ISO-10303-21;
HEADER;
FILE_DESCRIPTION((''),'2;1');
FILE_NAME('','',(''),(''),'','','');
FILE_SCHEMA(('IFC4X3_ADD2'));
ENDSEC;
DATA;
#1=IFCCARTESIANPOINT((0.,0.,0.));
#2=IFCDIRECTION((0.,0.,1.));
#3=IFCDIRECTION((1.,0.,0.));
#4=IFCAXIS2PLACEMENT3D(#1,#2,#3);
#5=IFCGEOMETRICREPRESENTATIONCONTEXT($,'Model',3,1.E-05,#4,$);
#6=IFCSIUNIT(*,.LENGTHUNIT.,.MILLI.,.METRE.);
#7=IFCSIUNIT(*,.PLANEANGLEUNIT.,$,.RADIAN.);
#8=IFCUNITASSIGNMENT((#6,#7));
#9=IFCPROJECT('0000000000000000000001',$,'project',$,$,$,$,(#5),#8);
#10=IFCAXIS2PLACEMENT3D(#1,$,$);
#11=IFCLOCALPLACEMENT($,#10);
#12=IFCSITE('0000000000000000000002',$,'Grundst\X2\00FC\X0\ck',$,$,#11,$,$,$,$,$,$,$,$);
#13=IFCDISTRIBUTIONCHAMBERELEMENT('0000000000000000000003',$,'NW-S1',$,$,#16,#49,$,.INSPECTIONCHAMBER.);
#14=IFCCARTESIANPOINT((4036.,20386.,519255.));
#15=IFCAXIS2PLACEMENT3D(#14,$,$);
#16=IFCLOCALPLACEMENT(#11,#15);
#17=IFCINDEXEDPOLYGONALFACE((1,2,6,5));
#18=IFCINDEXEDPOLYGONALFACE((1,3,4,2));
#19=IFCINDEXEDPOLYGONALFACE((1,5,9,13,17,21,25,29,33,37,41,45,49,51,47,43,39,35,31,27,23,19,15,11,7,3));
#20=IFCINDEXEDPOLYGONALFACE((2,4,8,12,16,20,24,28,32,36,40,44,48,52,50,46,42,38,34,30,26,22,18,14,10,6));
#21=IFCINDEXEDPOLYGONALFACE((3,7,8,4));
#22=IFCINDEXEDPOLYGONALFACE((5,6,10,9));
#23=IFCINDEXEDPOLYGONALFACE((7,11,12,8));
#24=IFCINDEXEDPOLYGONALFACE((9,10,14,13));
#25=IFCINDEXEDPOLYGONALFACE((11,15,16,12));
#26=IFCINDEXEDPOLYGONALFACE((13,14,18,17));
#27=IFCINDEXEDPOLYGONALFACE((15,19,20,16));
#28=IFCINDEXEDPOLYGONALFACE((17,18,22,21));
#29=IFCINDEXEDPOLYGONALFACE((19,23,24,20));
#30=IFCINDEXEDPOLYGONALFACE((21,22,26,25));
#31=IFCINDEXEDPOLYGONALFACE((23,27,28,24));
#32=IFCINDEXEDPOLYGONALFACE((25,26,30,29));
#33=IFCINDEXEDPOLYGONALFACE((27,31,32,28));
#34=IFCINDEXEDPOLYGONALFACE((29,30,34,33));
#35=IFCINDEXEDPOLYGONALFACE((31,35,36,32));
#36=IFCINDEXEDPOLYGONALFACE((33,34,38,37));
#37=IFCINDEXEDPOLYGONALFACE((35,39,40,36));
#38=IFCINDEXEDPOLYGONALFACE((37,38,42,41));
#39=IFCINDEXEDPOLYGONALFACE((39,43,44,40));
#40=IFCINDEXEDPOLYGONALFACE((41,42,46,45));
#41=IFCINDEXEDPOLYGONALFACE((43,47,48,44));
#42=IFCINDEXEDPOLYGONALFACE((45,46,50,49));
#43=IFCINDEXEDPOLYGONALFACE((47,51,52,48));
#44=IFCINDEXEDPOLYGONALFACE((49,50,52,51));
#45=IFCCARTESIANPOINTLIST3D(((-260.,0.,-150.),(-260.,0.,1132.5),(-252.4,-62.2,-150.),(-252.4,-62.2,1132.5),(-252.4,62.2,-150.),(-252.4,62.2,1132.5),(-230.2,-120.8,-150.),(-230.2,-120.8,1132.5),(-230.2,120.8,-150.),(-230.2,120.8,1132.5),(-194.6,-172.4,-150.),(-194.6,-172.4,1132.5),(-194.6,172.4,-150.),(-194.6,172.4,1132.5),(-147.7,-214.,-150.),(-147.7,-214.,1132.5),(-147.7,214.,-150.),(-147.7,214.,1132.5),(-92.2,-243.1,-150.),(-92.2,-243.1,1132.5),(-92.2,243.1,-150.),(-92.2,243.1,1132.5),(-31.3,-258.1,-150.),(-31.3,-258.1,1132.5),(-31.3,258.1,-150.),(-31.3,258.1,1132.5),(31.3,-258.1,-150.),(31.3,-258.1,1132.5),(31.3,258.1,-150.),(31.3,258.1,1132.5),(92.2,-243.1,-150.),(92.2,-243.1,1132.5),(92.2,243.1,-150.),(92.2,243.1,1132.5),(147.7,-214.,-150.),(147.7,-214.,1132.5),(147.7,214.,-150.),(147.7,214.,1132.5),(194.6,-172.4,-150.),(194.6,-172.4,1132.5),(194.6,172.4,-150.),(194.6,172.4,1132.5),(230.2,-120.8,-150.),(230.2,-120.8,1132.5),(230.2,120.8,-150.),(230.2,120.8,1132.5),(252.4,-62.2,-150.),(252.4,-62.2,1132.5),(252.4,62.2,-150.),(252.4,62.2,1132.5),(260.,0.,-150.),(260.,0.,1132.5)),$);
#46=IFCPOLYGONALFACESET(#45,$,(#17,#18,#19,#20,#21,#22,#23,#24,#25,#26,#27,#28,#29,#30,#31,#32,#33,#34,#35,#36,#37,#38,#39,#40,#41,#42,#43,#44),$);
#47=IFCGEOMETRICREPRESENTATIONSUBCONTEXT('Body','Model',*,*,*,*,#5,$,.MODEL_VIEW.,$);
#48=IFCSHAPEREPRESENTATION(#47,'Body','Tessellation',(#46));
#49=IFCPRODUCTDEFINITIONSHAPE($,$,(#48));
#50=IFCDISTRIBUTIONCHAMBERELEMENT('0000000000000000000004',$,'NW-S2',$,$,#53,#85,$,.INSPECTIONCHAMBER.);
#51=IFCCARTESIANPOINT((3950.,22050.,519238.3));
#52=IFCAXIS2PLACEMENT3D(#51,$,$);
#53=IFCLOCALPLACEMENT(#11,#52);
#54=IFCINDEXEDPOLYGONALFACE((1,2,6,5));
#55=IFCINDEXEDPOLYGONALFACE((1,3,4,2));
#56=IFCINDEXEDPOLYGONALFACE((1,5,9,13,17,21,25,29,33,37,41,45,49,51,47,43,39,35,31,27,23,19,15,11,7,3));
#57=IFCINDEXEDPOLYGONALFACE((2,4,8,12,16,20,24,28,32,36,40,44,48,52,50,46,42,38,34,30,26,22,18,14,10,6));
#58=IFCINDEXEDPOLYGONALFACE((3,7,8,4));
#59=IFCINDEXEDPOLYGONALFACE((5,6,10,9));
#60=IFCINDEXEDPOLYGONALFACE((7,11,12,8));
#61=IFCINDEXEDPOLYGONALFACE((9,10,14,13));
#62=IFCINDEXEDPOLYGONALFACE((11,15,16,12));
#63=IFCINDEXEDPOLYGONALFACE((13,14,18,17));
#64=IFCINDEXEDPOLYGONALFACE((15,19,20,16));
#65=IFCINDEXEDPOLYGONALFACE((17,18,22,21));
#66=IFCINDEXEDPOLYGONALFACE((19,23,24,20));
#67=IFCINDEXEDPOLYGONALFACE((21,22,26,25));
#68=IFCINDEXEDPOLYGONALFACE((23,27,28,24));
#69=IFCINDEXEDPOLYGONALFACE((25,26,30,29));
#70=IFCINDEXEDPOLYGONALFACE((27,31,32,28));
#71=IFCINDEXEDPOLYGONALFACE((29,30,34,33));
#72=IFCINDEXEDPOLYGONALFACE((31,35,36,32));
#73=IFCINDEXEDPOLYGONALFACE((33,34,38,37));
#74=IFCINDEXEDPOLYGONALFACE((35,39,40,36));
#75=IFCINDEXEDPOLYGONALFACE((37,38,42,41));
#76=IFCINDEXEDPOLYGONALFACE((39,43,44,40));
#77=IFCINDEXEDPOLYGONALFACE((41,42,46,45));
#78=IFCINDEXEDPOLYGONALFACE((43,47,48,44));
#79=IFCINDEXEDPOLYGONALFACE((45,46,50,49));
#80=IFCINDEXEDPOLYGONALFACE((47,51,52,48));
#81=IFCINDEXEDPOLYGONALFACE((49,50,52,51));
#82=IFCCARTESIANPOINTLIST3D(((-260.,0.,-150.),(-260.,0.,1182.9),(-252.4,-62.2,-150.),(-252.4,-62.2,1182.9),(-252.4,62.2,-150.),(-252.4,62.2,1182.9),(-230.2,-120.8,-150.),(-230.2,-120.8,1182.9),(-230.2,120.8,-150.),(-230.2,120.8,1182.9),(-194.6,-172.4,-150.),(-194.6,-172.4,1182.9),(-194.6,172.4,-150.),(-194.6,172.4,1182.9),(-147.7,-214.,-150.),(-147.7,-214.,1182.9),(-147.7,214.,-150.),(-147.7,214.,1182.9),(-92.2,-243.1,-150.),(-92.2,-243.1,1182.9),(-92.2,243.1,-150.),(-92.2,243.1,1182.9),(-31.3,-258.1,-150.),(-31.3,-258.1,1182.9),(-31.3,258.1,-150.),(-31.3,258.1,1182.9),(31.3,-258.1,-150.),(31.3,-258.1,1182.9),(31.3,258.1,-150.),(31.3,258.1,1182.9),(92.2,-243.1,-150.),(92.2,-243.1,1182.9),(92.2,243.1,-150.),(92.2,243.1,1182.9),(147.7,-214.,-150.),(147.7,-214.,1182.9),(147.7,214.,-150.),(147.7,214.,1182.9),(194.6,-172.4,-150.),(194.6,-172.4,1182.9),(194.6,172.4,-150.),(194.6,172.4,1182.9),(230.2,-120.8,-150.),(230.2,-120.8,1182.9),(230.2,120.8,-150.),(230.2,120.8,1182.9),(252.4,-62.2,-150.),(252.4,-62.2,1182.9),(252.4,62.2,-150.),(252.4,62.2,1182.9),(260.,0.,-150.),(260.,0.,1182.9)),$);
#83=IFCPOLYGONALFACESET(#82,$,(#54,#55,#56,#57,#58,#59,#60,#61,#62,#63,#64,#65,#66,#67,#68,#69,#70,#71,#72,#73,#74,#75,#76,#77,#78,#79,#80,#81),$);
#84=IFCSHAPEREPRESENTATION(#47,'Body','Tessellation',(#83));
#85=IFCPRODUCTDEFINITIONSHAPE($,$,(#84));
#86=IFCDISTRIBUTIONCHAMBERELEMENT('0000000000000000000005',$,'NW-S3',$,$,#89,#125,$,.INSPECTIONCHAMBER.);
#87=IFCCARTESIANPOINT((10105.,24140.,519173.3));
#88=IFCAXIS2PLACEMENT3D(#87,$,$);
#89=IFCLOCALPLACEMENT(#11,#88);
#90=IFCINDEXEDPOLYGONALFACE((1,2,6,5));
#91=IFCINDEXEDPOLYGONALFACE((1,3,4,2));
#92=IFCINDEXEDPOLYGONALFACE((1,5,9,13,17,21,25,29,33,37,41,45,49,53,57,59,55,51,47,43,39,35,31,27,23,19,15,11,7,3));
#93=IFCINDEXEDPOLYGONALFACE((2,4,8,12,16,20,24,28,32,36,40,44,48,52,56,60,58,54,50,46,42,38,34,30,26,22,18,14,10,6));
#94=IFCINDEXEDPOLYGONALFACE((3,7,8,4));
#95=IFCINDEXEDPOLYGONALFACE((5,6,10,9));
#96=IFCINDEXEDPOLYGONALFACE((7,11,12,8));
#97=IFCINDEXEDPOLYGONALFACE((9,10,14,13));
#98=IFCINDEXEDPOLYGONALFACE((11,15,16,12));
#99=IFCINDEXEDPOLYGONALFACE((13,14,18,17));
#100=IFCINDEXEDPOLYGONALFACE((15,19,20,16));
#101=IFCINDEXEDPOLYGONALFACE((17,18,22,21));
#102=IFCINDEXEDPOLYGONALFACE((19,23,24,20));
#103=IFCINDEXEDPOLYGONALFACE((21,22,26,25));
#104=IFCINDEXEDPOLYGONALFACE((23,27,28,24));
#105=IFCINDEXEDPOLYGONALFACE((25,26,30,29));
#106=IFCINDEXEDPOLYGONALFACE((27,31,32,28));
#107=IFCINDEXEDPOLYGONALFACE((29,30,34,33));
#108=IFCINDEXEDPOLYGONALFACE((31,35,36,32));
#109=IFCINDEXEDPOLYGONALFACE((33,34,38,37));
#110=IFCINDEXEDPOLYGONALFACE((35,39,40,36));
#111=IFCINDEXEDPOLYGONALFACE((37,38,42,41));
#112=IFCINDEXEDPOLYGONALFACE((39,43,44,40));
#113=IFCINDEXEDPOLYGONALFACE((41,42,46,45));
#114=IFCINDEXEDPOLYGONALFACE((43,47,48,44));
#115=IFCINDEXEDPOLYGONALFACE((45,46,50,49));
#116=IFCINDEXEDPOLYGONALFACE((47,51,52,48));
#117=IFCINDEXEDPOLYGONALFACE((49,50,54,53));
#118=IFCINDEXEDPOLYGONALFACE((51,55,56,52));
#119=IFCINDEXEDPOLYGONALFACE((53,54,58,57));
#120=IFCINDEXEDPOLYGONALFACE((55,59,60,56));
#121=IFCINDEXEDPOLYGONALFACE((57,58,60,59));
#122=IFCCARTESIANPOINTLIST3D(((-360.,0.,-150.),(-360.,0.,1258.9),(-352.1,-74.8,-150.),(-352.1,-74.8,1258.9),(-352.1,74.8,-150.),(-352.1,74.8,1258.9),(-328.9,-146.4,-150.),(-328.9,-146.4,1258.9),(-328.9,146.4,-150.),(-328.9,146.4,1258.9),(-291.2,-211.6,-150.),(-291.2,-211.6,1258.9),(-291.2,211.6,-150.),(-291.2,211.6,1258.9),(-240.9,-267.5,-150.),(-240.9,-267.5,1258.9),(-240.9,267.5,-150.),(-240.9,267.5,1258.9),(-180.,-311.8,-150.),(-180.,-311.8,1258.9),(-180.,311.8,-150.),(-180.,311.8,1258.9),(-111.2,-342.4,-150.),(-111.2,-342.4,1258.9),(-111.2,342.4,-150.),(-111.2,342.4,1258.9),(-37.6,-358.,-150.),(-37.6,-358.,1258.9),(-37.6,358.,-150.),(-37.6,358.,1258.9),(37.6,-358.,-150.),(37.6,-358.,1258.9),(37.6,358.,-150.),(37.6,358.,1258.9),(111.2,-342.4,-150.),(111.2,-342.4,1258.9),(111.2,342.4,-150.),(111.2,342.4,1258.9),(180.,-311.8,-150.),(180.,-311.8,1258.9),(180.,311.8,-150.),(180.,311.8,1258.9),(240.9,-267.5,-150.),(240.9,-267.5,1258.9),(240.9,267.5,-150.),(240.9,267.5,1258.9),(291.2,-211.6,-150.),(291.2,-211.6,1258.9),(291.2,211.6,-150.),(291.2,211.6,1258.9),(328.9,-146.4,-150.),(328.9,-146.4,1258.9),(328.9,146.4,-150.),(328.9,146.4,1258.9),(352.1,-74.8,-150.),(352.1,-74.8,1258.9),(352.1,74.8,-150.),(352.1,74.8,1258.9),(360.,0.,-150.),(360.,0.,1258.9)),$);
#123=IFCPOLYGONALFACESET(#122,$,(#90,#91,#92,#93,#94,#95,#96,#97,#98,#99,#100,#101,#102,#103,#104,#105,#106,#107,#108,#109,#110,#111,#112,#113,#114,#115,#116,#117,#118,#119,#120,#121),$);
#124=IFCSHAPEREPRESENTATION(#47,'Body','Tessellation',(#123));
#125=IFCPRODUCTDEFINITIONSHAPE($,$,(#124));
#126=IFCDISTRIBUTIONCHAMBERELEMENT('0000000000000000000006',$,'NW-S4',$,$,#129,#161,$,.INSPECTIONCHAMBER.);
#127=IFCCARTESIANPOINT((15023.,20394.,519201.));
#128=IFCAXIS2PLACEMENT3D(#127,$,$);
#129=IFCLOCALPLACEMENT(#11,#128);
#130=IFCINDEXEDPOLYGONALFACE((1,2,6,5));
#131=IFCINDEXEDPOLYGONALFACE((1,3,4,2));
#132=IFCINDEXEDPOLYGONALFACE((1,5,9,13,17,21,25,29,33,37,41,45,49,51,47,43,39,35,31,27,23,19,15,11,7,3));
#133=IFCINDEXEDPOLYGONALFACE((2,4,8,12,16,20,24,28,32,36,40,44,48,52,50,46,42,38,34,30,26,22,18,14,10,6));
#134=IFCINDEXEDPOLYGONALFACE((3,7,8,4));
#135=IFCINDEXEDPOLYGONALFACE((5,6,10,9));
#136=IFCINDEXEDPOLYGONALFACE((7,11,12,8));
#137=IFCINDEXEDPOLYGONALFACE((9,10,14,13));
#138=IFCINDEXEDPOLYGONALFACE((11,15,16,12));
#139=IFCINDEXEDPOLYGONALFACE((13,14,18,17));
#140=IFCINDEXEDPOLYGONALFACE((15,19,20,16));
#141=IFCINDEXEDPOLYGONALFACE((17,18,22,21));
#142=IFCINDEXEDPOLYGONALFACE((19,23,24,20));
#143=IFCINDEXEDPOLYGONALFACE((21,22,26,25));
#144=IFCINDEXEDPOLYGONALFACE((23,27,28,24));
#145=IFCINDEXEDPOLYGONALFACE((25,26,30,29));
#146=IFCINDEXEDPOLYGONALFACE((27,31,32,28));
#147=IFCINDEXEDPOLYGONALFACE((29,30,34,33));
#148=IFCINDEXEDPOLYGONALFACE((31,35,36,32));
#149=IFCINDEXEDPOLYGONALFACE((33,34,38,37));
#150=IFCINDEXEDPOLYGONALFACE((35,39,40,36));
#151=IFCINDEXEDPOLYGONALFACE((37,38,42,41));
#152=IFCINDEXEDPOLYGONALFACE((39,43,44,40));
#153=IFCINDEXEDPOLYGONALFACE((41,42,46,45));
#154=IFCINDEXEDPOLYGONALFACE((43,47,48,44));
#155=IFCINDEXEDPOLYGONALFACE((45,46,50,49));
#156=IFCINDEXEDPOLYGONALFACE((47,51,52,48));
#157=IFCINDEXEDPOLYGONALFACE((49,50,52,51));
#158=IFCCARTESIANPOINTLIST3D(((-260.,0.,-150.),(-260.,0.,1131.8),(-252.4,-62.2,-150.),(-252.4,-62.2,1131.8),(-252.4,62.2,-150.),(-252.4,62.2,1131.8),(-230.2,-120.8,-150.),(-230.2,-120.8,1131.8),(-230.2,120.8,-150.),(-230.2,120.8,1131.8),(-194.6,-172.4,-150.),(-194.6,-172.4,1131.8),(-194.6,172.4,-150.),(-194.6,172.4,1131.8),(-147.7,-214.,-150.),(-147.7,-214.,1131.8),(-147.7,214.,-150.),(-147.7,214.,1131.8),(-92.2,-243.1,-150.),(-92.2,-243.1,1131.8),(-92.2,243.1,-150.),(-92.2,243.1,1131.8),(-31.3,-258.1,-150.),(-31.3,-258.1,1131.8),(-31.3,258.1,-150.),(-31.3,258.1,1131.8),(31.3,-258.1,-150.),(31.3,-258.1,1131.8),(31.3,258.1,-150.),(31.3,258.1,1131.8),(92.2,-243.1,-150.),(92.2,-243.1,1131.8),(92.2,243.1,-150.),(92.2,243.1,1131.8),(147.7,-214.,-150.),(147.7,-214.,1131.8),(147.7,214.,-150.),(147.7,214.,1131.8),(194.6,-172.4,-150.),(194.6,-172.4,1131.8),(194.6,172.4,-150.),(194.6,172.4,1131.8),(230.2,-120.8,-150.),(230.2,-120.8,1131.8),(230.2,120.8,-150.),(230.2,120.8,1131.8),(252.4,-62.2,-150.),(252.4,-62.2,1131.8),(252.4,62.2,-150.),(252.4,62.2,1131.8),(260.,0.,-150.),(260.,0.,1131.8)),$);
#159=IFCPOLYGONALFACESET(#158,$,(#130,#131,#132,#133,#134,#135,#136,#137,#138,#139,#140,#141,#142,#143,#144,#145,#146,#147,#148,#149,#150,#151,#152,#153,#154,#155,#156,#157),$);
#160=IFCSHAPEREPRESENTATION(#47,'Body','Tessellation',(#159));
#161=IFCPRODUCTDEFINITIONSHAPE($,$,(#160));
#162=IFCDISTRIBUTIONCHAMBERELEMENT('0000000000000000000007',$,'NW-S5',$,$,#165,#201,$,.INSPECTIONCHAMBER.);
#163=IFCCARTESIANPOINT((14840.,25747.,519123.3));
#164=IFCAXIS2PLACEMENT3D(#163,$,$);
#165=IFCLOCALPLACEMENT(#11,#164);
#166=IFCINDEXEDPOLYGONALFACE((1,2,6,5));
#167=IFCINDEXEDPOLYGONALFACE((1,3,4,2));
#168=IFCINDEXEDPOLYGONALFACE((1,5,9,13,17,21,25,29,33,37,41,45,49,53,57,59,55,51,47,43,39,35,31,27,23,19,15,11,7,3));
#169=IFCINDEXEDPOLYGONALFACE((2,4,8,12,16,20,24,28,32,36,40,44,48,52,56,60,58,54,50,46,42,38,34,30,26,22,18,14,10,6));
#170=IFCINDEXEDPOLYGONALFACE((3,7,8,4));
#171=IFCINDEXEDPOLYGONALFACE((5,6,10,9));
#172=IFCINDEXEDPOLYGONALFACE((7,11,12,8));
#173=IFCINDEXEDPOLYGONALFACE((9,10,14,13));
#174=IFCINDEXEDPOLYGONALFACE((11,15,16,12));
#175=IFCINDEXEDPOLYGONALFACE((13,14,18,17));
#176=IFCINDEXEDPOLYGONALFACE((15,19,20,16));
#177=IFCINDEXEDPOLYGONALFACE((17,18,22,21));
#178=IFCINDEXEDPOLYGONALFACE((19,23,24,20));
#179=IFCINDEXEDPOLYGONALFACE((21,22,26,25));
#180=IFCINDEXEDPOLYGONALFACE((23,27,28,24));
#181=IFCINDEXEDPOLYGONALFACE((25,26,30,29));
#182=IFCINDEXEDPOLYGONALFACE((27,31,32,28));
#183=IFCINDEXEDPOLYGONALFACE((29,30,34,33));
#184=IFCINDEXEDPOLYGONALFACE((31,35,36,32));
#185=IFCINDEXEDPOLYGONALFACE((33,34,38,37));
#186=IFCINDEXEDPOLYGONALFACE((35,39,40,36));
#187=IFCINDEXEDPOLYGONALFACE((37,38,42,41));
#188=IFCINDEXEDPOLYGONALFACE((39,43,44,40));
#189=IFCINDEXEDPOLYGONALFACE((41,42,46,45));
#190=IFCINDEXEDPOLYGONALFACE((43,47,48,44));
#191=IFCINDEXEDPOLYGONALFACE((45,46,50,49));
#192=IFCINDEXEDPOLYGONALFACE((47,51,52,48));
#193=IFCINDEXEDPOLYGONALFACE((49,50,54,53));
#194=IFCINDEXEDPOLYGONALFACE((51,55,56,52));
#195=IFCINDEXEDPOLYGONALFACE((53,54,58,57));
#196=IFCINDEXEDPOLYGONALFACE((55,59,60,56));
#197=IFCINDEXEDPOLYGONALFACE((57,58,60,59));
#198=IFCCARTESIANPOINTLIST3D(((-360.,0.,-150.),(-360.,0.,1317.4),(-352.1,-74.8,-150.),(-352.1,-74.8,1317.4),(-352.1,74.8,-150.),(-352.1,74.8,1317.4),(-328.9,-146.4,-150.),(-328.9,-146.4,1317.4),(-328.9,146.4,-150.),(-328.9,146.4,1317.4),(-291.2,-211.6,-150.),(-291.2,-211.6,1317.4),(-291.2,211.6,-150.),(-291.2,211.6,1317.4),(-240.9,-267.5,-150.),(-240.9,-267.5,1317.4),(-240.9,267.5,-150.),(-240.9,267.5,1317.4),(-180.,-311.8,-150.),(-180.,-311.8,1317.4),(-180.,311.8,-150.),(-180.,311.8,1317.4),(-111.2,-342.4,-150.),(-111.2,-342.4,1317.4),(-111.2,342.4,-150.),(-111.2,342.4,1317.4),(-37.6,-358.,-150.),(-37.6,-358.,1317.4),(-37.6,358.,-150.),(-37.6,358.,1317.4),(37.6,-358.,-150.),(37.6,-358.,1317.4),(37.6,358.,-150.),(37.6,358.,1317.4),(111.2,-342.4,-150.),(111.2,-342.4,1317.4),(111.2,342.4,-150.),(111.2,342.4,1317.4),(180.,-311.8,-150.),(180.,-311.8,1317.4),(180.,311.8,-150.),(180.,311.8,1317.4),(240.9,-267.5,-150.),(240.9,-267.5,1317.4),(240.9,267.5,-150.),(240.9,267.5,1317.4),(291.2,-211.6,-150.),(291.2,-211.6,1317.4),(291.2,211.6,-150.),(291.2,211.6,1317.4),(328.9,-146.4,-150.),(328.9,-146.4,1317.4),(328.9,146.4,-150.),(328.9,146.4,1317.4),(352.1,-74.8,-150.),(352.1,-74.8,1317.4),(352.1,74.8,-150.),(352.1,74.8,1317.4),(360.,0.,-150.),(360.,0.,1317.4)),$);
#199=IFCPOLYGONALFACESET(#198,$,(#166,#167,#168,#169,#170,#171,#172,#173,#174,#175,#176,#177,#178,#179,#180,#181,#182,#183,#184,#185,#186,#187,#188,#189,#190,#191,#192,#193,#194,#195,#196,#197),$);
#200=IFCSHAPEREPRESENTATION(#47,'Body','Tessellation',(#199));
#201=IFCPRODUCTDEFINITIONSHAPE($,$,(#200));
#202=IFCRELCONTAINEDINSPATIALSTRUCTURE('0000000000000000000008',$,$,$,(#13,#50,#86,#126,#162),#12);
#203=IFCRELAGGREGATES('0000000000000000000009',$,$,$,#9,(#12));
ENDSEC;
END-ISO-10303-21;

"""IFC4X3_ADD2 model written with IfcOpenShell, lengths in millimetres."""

from ifc_helpers import new_model, si_unit, frame, origin, origin_with_axes, place, context, subcontext, project, spatial, circle, extrude, element, save


model = new_model("IFC4X3_ADD2")

# Units and contexts
model_context = context("Model", 3, precision=1e-05, world=origin_with_axes())
body_context = subcontext(model_context, "Body", "Model", "MODEL_VIEW")
ifc_project = project(units=[si_unit("LENGTHUNIT", "METRE", prefix="MILLI"), si_unit("PLANEANGLEUNIT", "RADIAN")], contexts=[model_context])

# Site
site_placement = place(None, origin())
site = spatial("IfcSite", under=ifc_project, at=site_placement, Name="Grundstück")

# Distribution chamber elements
distribution_chamber_element_1_placement = place(site_placement, frame((4036.0, 20386.0, 519255.0)))
element("IfcDistributionChamberElement", 1, at=distribution_chamber_element_1_placement, inside=site, Name="NW-S1", PredefinedType="INSPECTIONCHAMBER", context=body_context, shape_type="SweptSolid", body=[
    extrude(circle(Radius=260.0), frame((0.0, 0.0, -150.0)), (0.0, 0.0, 1.0), 1282.5),
])
distribution_chamber_element_2_placement = place(site_placement, frame((3950.0, 22050.0, 519238.3)))
element("IfcDistributionChamberElement", 2, at=distribution_chamber_element_2_placement, inside=site, Name="NW-S2", PredefinedType="INSPECTIONCHAMBER", context=body_context, shape_type="SweptSolid", body=[
    extrude(circle(Radius=260.0), frame((0.0, 0.0, -150.0)), (0.0, 0.0, 1.0), 1332.9),
])
distribution_chamber_element_3_placement = place(site_placement, frame((10105.0, 24140.0, 519173.3)))
element("IfcDistributionChamberElement", 3, at=distribution_chamber_element_3_placement, inside=site, Name="NW-S3", PredefinedType="INSPECTIONCHAMBER", context=body_context, shape_type="SweptSolid", body=[
    extrude(circle(Radius=360.0), frame((0.0, 0.0, -150.0)), (0.0, 0.0, 1.0), 1408.9),
])
distribution_chamber_element_4_placement = place(site_placement, frame((15023.0, 20394.0, 519201.0)))
element("IfcDistributionChamberElement", 4, at=distribution_chamber_element_4_placement, inside=site, Name="NW-S4", PredefinedType="INSPECTIONCHAMBER", context=body_context, shape_type="SweptSolid", body=[
    extrude(circle(Radius=260.0), frame((0.0, 0.0, -150.0)), (0.0, 0.0, 1.0), 1281.8),
])
distribution_chamber_element_5_placement = place(site_placement, frame((14840.0, 25747.0, 519123.3)))
element("IfcDistributionChamberElement", 5, at=distribution_chamber_element_5_placement, inside=site, Name="NW-S5", PredefinedType="INSPECTIONCHAMBER", context=body_context, shape_type="SweptSolid", body=[
    extrude(circle(Radius=360.0), frame((0.0, 0.0, -150.0)), (0.0, 0.0, 1.0), 1467.4),
])

save(model, "model.ifc")
